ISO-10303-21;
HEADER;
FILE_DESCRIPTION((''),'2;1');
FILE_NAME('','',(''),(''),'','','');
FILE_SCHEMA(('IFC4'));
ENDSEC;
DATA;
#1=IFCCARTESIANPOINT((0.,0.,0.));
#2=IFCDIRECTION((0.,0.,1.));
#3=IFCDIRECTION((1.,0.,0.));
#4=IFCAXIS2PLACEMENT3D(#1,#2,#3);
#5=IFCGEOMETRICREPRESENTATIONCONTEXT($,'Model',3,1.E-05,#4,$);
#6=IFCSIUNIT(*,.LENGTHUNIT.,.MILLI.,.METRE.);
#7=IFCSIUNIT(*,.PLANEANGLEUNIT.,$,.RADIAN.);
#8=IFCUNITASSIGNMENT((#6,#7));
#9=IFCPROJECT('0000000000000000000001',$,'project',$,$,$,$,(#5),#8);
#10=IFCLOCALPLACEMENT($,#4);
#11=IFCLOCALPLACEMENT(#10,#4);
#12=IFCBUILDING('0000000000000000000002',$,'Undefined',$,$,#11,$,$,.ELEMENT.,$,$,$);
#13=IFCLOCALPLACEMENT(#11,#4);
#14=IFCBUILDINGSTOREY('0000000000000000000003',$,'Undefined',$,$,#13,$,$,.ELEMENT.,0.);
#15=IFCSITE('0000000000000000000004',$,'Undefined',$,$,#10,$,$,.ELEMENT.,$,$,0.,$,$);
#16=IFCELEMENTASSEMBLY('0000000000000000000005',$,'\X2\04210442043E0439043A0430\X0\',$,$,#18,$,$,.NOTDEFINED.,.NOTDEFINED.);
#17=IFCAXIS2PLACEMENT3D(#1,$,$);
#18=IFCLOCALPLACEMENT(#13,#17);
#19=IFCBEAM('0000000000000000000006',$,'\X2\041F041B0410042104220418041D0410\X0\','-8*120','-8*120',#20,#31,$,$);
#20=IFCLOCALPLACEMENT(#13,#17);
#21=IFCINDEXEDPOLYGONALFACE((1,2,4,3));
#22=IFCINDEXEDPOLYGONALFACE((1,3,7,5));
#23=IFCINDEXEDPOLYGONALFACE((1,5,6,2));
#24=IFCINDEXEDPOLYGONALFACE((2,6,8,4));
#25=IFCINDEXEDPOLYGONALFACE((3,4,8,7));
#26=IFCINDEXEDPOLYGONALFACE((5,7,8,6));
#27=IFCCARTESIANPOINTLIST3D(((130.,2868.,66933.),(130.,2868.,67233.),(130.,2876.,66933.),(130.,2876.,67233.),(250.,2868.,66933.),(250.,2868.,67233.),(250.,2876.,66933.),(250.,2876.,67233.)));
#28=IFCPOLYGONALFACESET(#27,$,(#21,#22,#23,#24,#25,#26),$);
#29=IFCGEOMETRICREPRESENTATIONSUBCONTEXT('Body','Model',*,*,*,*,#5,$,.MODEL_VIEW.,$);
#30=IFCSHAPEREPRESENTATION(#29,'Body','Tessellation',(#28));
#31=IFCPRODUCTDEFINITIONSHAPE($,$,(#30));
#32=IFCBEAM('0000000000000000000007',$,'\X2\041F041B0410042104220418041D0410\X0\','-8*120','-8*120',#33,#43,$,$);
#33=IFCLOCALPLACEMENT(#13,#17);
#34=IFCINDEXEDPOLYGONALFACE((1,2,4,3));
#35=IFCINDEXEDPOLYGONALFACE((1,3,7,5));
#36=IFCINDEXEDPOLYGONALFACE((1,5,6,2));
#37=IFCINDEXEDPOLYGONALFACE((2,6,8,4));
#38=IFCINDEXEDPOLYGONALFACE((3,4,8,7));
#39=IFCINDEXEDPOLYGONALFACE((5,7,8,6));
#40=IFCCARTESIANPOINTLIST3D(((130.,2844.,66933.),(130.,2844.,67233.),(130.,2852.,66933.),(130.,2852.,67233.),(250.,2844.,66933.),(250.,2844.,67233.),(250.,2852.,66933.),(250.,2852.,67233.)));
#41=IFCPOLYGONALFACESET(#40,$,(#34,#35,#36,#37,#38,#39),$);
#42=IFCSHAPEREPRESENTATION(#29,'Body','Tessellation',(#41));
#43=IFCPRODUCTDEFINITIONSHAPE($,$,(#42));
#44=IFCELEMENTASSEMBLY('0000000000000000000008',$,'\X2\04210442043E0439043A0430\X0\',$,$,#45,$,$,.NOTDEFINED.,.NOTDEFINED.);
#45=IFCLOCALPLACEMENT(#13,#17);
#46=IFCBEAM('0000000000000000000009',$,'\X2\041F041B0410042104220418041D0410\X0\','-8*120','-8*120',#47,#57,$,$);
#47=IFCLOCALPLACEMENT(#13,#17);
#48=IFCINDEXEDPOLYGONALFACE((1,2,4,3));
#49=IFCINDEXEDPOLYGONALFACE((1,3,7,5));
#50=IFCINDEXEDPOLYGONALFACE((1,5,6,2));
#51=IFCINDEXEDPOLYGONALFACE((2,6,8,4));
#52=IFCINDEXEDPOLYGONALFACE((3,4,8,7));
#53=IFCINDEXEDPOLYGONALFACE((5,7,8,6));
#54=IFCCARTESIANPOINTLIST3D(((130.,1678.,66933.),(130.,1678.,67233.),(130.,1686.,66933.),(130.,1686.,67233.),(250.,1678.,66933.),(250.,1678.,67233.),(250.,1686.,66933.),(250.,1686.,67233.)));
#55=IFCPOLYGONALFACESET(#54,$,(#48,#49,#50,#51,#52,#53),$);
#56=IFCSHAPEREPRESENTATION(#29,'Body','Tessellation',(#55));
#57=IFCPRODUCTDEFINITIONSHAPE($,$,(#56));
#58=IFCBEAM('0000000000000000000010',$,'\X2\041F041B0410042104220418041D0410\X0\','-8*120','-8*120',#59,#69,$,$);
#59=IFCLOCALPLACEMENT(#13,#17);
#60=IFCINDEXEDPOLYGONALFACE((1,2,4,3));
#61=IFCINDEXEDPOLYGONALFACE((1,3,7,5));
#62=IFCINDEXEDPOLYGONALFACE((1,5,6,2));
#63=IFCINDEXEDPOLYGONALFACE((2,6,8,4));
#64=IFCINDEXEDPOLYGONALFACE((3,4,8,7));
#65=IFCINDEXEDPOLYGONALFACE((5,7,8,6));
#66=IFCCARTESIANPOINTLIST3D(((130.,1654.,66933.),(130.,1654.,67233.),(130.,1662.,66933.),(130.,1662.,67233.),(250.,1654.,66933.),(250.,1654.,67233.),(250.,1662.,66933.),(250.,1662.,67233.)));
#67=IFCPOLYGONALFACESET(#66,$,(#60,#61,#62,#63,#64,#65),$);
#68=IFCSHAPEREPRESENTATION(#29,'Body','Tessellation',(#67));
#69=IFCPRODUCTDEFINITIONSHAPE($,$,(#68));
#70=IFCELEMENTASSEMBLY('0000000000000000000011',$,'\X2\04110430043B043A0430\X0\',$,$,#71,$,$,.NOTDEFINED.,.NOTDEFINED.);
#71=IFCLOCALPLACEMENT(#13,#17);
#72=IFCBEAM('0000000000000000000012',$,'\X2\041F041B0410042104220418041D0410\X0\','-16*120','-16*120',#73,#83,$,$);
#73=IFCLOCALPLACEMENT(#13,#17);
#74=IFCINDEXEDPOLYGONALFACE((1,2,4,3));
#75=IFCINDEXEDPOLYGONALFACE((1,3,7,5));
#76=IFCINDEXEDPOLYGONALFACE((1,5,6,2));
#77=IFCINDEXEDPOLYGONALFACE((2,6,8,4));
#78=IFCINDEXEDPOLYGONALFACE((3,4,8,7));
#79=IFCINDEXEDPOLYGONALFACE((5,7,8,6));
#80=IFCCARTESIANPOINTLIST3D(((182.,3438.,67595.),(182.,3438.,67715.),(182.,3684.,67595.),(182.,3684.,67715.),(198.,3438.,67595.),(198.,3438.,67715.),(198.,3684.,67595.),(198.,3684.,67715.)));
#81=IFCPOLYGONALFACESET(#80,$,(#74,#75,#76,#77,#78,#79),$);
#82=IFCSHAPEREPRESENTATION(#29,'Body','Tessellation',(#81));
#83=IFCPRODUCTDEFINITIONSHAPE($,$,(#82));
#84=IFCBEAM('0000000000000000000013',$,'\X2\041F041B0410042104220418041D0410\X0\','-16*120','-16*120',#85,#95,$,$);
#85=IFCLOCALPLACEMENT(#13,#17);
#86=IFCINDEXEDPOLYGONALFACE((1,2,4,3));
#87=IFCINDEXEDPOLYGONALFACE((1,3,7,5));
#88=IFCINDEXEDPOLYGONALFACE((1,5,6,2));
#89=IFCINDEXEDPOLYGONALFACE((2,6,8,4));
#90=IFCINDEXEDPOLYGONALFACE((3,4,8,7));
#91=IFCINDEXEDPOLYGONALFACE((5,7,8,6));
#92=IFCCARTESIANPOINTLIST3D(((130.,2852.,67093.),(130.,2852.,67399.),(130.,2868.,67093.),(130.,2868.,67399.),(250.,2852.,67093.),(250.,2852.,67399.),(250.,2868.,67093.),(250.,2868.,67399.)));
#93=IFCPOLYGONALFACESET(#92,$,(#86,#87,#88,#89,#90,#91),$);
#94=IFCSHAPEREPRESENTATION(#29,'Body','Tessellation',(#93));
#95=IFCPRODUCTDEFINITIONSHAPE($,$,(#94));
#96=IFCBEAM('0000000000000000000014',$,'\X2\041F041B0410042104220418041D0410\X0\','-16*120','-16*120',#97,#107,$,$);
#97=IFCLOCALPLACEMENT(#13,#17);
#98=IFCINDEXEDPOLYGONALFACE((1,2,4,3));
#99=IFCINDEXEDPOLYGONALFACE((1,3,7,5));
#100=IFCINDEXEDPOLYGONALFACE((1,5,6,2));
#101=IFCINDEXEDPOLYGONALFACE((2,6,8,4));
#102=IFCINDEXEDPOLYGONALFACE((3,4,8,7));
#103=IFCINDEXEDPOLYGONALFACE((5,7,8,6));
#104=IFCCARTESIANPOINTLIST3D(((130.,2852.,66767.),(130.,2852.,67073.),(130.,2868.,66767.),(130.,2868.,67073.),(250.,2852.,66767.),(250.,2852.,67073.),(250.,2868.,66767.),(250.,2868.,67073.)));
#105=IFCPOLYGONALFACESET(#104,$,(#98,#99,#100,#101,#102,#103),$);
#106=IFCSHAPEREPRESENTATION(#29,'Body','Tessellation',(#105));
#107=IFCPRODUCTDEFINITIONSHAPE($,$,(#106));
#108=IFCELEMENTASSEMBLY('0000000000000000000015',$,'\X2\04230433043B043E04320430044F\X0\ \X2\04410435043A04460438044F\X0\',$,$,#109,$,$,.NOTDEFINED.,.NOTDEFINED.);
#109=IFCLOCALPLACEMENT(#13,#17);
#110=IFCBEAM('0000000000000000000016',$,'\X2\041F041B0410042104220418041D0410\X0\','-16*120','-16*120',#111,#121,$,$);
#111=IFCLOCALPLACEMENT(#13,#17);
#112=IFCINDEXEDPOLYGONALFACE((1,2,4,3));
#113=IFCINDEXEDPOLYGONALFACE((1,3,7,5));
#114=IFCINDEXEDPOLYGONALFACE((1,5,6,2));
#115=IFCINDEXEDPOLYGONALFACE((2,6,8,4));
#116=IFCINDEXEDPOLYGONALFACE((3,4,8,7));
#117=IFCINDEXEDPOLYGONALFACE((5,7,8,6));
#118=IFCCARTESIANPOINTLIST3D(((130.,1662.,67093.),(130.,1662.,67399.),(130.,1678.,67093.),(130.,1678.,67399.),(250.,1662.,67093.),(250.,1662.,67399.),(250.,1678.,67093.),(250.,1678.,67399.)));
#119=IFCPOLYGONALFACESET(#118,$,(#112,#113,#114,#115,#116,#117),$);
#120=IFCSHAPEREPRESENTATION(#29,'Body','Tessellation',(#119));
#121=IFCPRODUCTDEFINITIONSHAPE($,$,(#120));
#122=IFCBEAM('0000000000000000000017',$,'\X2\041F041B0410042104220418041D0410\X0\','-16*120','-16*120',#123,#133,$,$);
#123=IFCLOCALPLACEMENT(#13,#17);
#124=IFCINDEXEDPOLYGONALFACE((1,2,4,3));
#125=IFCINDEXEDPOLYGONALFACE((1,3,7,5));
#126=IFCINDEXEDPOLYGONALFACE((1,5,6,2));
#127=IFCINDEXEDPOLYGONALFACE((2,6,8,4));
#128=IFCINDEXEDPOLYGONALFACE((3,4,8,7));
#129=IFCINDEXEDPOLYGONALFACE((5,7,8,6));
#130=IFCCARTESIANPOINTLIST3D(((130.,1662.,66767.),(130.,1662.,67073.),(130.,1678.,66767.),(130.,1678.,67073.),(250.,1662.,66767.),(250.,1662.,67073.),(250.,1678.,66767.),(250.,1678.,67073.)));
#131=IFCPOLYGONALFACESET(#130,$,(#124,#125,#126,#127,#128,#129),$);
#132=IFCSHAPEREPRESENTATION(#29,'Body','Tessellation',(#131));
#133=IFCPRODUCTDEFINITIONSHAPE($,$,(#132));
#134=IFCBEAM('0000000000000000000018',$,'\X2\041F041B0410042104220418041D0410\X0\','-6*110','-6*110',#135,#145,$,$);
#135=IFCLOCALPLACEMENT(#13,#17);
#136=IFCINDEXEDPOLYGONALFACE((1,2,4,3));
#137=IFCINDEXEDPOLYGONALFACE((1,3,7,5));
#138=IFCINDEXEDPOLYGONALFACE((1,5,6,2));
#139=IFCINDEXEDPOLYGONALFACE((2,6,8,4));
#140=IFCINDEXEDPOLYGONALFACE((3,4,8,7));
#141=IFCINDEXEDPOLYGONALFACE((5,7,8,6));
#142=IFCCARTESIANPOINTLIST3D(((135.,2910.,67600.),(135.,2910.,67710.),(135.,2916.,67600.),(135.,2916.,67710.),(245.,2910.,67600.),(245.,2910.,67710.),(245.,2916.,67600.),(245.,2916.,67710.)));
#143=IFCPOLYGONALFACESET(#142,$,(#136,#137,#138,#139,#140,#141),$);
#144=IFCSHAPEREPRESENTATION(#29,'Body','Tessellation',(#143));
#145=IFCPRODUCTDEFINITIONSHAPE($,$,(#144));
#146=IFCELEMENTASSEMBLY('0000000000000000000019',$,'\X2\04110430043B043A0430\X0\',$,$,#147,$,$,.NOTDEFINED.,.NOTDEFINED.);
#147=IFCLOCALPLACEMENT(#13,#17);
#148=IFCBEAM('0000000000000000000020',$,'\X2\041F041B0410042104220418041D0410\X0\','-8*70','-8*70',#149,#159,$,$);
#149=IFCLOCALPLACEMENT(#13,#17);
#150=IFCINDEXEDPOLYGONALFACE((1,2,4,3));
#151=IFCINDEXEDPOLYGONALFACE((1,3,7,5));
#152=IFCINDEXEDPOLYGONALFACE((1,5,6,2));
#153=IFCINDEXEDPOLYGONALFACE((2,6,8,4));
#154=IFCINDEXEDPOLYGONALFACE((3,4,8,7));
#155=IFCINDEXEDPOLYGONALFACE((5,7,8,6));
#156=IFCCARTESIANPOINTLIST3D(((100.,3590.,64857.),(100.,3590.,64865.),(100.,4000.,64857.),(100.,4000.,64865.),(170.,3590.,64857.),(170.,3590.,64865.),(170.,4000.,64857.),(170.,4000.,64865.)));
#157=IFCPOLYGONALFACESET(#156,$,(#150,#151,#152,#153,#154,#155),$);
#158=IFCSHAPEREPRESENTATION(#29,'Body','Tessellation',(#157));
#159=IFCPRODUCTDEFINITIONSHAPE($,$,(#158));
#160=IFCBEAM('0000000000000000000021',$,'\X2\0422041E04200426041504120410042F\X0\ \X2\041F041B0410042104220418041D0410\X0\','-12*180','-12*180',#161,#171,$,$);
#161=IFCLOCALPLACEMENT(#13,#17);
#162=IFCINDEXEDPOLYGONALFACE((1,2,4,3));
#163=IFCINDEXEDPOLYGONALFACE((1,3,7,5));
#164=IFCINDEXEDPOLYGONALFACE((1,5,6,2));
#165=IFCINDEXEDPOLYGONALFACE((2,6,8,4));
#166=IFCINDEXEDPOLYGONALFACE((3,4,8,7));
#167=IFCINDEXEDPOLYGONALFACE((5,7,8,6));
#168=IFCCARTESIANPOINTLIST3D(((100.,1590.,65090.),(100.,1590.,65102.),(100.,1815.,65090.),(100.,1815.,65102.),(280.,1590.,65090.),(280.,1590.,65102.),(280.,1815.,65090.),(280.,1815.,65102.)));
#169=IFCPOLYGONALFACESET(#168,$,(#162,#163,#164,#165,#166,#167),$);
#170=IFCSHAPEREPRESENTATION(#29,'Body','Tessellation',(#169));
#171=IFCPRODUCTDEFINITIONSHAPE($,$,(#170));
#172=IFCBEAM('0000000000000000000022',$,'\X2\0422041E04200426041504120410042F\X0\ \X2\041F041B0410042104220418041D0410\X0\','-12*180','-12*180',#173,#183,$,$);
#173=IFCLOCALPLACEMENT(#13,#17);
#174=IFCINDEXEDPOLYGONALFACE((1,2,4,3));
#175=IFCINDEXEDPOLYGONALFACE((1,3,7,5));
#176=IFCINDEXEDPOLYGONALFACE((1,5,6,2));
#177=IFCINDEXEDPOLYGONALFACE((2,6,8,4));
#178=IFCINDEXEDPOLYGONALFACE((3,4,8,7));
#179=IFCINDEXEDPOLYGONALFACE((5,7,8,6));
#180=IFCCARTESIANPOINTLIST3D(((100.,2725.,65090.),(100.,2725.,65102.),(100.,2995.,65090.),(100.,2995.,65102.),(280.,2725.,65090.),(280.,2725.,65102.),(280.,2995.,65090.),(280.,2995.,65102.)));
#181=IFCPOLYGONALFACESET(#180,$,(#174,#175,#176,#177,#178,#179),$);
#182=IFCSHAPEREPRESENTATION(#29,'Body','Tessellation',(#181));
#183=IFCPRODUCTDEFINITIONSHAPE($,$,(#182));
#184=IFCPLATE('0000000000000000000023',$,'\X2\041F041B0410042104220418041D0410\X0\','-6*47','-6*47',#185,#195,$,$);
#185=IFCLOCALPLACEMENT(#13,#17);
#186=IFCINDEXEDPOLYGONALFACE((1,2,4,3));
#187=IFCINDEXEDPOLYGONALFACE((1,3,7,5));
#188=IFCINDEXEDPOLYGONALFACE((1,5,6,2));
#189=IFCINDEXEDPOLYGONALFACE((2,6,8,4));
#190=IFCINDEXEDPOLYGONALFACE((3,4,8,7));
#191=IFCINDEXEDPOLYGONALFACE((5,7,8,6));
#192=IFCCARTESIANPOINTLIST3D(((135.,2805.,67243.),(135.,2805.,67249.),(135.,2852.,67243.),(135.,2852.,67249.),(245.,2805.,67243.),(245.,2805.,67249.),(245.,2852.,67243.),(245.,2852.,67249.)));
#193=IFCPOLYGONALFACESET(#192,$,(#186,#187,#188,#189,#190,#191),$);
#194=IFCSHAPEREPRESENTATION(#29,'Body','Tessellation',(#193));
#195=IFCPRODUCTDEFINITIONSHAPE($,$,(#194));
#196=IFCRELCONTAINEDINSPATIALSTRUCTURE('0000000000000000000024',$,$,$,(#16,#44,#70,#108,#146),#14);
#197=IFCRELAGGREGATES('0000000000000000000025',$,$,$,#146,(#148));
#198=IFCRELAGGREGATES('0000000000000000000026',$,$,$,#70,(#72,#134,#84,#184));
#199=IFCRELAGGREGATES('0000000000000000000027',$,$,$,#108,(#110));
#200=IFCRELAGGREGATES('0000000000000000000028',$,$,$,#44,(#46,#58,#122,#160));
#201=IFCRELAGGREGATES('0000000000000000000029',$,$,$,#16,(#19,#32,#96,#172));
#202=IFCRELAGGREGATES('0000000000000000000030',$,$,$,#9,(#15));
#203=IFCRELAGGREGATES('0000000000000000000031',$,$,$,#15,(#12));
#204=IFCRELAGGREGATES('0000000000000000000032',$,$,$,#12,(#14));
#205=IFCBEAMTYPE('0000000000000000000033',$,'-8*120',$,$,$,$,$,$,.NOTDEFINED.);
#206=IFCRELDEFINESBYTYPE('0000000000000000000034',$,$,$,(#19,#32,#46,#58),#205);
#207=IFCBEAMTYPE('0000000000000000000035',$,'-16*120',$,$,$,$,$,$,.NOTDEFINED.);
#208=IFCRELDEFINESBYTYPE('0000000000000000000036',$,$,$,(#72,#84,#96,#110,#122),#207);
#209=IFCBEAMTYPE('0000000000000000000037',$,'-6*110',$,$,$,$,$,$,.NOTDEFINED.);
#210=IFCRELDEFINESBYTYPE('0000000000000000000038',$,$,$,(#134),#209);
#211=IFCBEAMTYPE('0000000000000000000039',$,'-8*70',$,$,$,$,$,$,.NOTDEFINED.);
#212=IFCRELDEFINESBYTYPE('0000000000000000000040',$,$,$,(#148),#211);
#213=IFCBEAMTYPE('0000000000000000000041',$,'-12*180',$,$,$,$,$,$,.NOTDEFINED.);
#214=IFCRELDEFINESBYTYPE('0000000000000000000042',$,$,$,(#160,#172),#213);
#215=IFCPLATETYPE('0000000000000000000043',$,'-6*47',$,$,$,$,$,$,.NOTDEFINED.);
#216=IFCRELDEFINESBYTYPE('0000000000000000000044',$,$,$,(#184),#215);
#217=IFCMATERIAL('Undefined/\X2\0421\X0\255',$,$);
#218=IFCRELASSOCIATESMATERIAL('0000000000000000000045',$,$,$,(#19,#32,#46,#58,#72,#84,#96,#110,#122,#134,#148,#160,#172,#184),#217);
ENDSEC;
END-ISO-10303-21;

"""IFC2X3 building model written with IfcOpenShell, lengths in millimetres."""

from ifc_helpers import new_model, si_unit, frame, origin_with_axes, origin_2d_with_axis, place, context, subcontext, project, spatial, polyline, rectangle, outline, extrude, boolean, material, type_object, element, aggregate, save


model = new_model("IFC2X3")

# Units and contexts
model_context = context("Model", 3, precision=1e-05, world=origin_with_axes())
body_context = subcontext(model_context, "Body", "Model", "MODEL_VIEW")
ifc_project = project(units=[si_unit("LENGTHUNIT", "METRE", prefix="MILLI"), si_unit("PLANEANGLEUNIT", "RADIAN")], contexts=[model_context])

# Site, building, storey
site_placement = place(None, origin_with_axes())
site = spatial("IfcSite", under=ifc_project, at=site_placement, Name="Undefined", CompositionType="ELEMENT", RefElevation=0.0)
building_placement = place(site_placement, origin_with_axes())
building = spatial("IfcBuilding", under=site, at=building_placement, Name="Undefined", CompositionType="ELEMENT")
storey_placement = place(building_placement, origin_with_axes())
storey = spatial("IfcBuildingStorey", under=building, at=storey_placement, Name="Undefined", CompositionType="ELEMENT", Elevation=0.0)

# Element assemblies, beams
assembly_1_placement = place(storey_placement, origin_with_axes())
assembly_1 = element("IfcElementAssembly", 1, at=assembly_1_placement, inside=storey, Name="Стойка", AssemblyPlace="NOTDEFINED", PredefinedType="NOTDEFINED")
ifc_material_1 = material(Name="Undefined/С255")
beam_type_1 = type_object("IfcBeamType", Name="-8*120", PredefinedType="NOTDEFINED")
beam_1_placement = place(assembly_1_placement, frame((190.0, 2872.0, 66933.0), z_axis=(1.0, 0.0, 0.0), x_axis=(0.0, 0.0, 1.0)))
beam_1 = element("IfcBeam", 2, at=beam_1_placement, type_object=beam_type_1, material=ifc_material_1, Name="ПЛАСТИНА", Description="-8*120", ObjectType="-8*120", context=body_context, shape_type="SweptSolid", body=[
    extrude(rectangle(XDim=8.0, YDim=120.0, at=origin_2d_with_axis()), frame((300.0, 0.0, 0.0), z_axis=(-1.0, 0.0, 0.0), x_axis=(0.0, -1.0, 0.0)), (0.0, 0.0, 1.0), 300.0),
])
beam_2_placement = place(assembly_1_placement, frame((190.0, 2848.0, 66933.0), z_axis=(1.0, 0.0, 0.0), x_axis=(0.0, 0.0, 1.0)))
beam_2 = element("IfcBeam", 3, at=beam_2_placement, type_object=beam_type_1, material=ifc_material_1, Name="ПЛАСТИНА", Description="-8*120", ObjectType="-8*120", context=body_context, shape_type="SweptSolid", body=[
    extrude(rectangle(XDim=8.0, YDim=120.0, at=origin_2d_with_axis()), frame((300.0, 0.0, 0.0), z_axis=(-1.0, 0.0, 0.0), x_axis=(0.0, -1.0, 0.0)), (0.0, 0.0, 1.0), 300.0),
])
assembly_2_placement = place(storey_placement, origin_with_axes())
assembly_2 = element("IfcElementAssembly", 4, at=assembly_2_placement, inside=storey, Name="Стойка", AssemblyPlace="NOTDEFINED", PredefinedType="NOTDEFINED")
beam_3_placement = place(assembly_2_placement, frame((190.0, 1682.0, 66933.0), z_axis=(1.0, 0.0, 0.0), x_axis=(0.0, 0.0, 1.0)))
beam_3 = element("IfcBeam", 5, at=beam_3_placement, type_object=beam_type_1, material=ifc_material_1, Name="ПЛАСТИНА", Description="-8*120", ObjectType="-8*120", context=body_context, shape_type="SweptSolid", body=[
    extrude(rectangle(XDim=8.0, YDim=120.0, at=origin_2d_with_axis()), frame((300.0, 0.0, 0.0), z_axis=(-1.0, 0.0, 0.0), x_axis=(0.0, -1.0, 0.0)), (0.0, 0.0, 1.0), 300.0),
])
beam_4_placement = place(assembly_2_placement, frame((190.0, 1658.0, 66933.0), z_axis=(1.0, 0.0, 0.0), x_axis=(0.0, 0.0, 1.0)))
beam_4 = element("IfcBeam", 6, at=beam_4_placement, type_object=beam_type_1, material=ifc_material_1, Name="ПЛАСТИНА", Description="-8*120", ObjectType="-8*120", context=body_context, shape_type="SweptSolid", body=[
    extrude(rectangle(XDim=8.0, YDim=120.0, at=origin_2d_with_axis()), frame((300.0, 0.0, 0.0), z_axis=(-1.0, 0.0, 0.0), x_axis=(0.0, -1.0, 0.0)), (0.0, 0.0, 1.0), 300.0),
])
assembly_3_placement = place(storey_placement, origin_with_axes())
assembly_3 = element("IfcElementAssembly", 7, at=assembly_3_placement, inside=storey, Name="Балка", AssemblyPlace="NOTDEFINED", PredefinedType="NOTDEFINED")
beam_type_2 = type_object("IfcBeamType", Name="-16*120", PredefinedType="NOTDEFINED")
beam_5_placement = place(assembly_3_placement, frame((190.0, 3438.0, 67655.0), z_axis=(0.0, 0.0, 1.0), x_axis=(0.0, 1.0, 0.0)))
beam_5 = element("IfcBeam", 8, at=beam_5_placement, type_object=beam_type_2, material=ifc_material_1, Name="ПЛАСТИНА", Description="-16*120", ObjectType="-16*120", context=body_context, shape_type="SweptSolid", body=[
    extrude(rectangle(XDim=16.0, YDim=120.0, at=origin_2d_with_axis()), frame((246.0, 0.0, 0.0), z_axis=(-1.0, 0.0, 0.0), x_axis=(0.0, -1.0, 0.0)), (0.0, 0.0, 1.0), 246.0),
])
beam_6_placement = place(assembly_3_placement, frame((190.0, 2860.0, 67093.0), z_axis=(1.0, 0.0, 0.0), x_axis=(0.0, 0.0, 1.0)))
beam_6 = element("IfcBeam", 9, at=beam_6_placement, type_object=beam_type_2, material=ifc_material_1, Name="ПЛАСТИНА", Description="-16*120", ObjectType="-16*120", context=body_context, shape_type="SweptSolid", body=[
    extrude(rectangle(XDim=16.0, YDim=120.0, at=origin_2d_with_axis()), frame((306.0, 0.0, 0.0), z_axis=(-1.0, 0.0, 0.0), x_axis=(0.0, -1.0, 0.0)), (0.0, 0.0, 1.0), 306.0),
])

# Beam
beam_7_placement = place(assembly_1_placement, frame((190.0, 2860.0, 66767.0), z_axis=(1.0, 0.0, 0.0), x_axis=(0.0, 0.0, 1.0)))
beam_7 = element("IfcBeam", 10, at=beam_7_placement, type_object=beam_type_2, material=ifc_material_1, Name="ПЛАСТИНА", Description="-16*120", ObjectType="-16*120", context=body_context, shape_type="SweptSolid", body=[
    extrude(rectangle(XDim=16.0, YDim=120.0, at=origin_2d_with_axis()), frame((306.0, 0.0, 0.0), z_axis=(-1.0, 0.0, 0.0), x_axis=(0.0, -1.0, 0.0)), (0.0, 0.0, 1.0), 306.0),
])

# Element assembly, beam
assembly_4_placement = place(storey_placement, origin_with_axes())
assembly_4 = element("IfcElementAssembly", 11, at=assembly_4_placement, inside=storey, Name="Угловая секция", AssemblyPlace="NOTDEFINED", PredefinedType="NOTDEFINED")
beam_8_placement = place(assembly_4_placement, frame((190.0, 1670.0, 67093.0), z_axis=(1.0, 0.0, 0.0), x_axis=(0.0, 0.0, 1.0)))
beam_8 = element("IfcBeam", 12, at=beam_8_placement, type_object=beam_type_2, material=ifc_material_1, Name="ПЛАСТИНА", Description="-16*120", ObjectType="-16*120", context=body_context, shape_type="SweptSolid", body=[
    extrude(rectangle(XDim=16.0, YDim=120.0, at=origin_2d_with_axis()), frame((306.0, 0.0, 0.0), z_axis=(-1.0, 0.0, 0.0), x_axis=(0.0, -1.0, 0.0)), (0.0, 0.0, 1.0), 306.0),
])

# Beams
beam_9_placement = place(assembly_2_placement, frame((190.0, 1670.0, 66767.0), z_axis=(1.0, 0.0, 0.0), x_axis=(0.0, 0.0, 1.0)))
beam_9 = element("IfcBeam", 13, at=beam_9_placement, type_object=beam_type_2, material=ifc_material_1, Name="ПЛАСТИНА", Description="-16*120", ObjectType="-16*120", context=body_context, shape_type="SweptSolid", body=[
    extrude(rectangle(XDim=16.0, YDim=120.0, at=origin_2d_with_axis()), frame((306.0, 0.0, 0.0), z_axis=(-1.0, 0.0, 0.0), x_axis=(0.0, -1.0, 0.0)), (0.0, 0.0, 1.0), 306.0),
])
beam_type_3 = type_object("IfcBeamType", Name="-6*110", PredefinedType="NOTDEFINED")
beam_10_placement = place(assembly_3_placement, frame((245.0, 2913.0, 67655.0), z_axis=(0.0, 0.0, 1.0), x_axis=(-1.0, 0.0, 0.0)))
beam_10 = element("IfcBeam", 14, at=beam_10_placement, type_object=beam_type_3, material=ifc_material_1, Name="ПЛАСТИНА", Description="-6*110", ObjectType="-6*110", context=body_context, shape_type="SweptSolid", body=[
    extrude(rectangle(XDim=6.0, YDim=110.0, at=origin_2d_with_axis()), frame((110.0, 0.0, 0.0), z_axis=(-1.0, 0.0, 0.0), x_axis=(0.0, -1.0, 0.0)), (0.0, 0.0, 1.0), 110.0),
])

# Element assembly, beam
assembly_5_placement = place(storey_placement, origin_with_axes())
assembly_5 = element("IfcElementAssembly", 15, at=assembly_5_placement, inside=storey, Name="Балка", AssemblyPlace="NOTDEFINED", PredefinedType="NOTDEFINED")
beam_type_4 = type_object("IfcBeamType", Name="-8*70", PredefinedType="NOTDEFINED")
beam_11_placement = place(assembly_5_placement, frame((135.0, 3590.0, 64861.0), z_axis=(-1.0, 0.0, 0.0), x_axis=(0.0, 1.0, 0.0)))
beam_11 = element("IfcBeam", 16, at=beam_11_placement, type_object=beam_type_4, material=ifc_material_1, Name="ПЛАСТИНА", Description="-8*70", ObjectType="-8*70", context=body_context, shape_type="SweptSolid", body=[
    extrude(rectangle(XDim=8.0, YDim=70.0, at=origin_2d_with_axis()), frame((410.0, 0.0, 0.0), z_axis=(-1.0, 0.0, 0.0), x_axis=(0.0, -1.0, 0.0)), (0.0, 0.0, 1.0), 410.0),
])
aggregate(assembly_5, [beam_11])

# Beams
beam_type_5 = type_object("IfcBeamType", Name="-12*180", PredefinedType="NOTDEFINED")
beam_12_placement = place(assembly_2_placement, frame((190.0, 1815.0, 65096.0), z_axis=(1.0, 0.0, 0.0), x_axis=(0.0, -1.0, 0.0)))
beam_12 = element("IfcBeam", 17, at=beam_12_placement, type_object=beam_type_5, material=ifc_material_1, Name="ТОРЦЕВАЯ ПЛАСТИНА", Description="-12*180", ObjectType="-12*180", context=body_context, shape_type="SweptSolid", body=[
    extrude(rectangle(XDim=12.0, YDim=180.0, at=origin_2d_with_axis()), frame((225.0, 0.0, 0.0), z_axis=(-1.0, 0.0, 0.0), x_axis=(0.0, -1.0, 0.0)), (0.0, 0.0, 1.0), 225.0),
])
beam_13_placement = place(assembly_1_placement, frame((190.0, 2995.0, 65096.0), z_axis=(1.0, 0.0, 0.0), x_axis=(0.0, -1.0, 0.0)))
beam_13 = element("IfcBeam", 18, at=beam_13_placement, type_object=beam_type_5, material=ifc_material_1, Name="ТОРЦЕВАЯ ПЛАСТИНА", Description="-12*180", ObjectType="-12*180", context=body_context, shape_type="SweptSolid", body=[
    extrude(rectangle(XDim=12.0, YDim=180.0, at=origin_2d_with_axis()), frame((270.0, 0.0, 0.0), z_axis=(-1.0, 0.0, 0.0), x_axis=(0.0, -1.0, 0.0)), (0.0, 0.0, 1.0), 270.0),
])

# Plate
plate_type_1 = type_object("IfcPlateType", Name="-6*47", PredefinedType="NOTDEFINED")
plate_1_placement = place(assembly_3_placement, frame((245.0, 2805.0, 67246.0), z_axis=(0.0, 0.0, -1.0), x_axis=(-1.0, 0.0, 0.0)))
plate_1 = element("IfcPlate", 19, at=plate_1_placement, type_object=plate_type_1, material=ifc_material_1, Name="ПЛАСТИНА", Description="-6*47", ObjectType="-6*47", context=body_context, shape_type="CSG", body=[
    boolean("DIFFERENCE", extrude(outline(polyline([(0.0, 0.0), (110.0, 0.0), (110.0, 110.0), (0.0, 110.0), (0.0, 0.0)])), frame((0.0, 0.0, -3.0), z_axis=(0.0, 0.0, 1.0), x_axis=(1.0, 0.0, 0.0)), (0.0, 0.0, 1.0), 6.0), extrude(rectangle(XDim=26.0, YDim=130.0, at=origin_2d_with_axis()), frame((55.0, 47.0, 0.0), z_axis=(0.0, 1.0, 0.0), x_axis=(0.0, 0.0, -1.0)), (0.0, 0.0, 1.0), 66.0)),
])
aggregate(assembly_3, [beam_5, beam_10, beam_6, plate_1])
aggregate(assembly_4, [beam_8])

aggregate(assembly_2, [beam_3, beam_4, beam_9, beam_12])
aggregate(assembly_1, [beam_1, beam_2, beam_7, beam_13])

save(model, "model.ifc")
